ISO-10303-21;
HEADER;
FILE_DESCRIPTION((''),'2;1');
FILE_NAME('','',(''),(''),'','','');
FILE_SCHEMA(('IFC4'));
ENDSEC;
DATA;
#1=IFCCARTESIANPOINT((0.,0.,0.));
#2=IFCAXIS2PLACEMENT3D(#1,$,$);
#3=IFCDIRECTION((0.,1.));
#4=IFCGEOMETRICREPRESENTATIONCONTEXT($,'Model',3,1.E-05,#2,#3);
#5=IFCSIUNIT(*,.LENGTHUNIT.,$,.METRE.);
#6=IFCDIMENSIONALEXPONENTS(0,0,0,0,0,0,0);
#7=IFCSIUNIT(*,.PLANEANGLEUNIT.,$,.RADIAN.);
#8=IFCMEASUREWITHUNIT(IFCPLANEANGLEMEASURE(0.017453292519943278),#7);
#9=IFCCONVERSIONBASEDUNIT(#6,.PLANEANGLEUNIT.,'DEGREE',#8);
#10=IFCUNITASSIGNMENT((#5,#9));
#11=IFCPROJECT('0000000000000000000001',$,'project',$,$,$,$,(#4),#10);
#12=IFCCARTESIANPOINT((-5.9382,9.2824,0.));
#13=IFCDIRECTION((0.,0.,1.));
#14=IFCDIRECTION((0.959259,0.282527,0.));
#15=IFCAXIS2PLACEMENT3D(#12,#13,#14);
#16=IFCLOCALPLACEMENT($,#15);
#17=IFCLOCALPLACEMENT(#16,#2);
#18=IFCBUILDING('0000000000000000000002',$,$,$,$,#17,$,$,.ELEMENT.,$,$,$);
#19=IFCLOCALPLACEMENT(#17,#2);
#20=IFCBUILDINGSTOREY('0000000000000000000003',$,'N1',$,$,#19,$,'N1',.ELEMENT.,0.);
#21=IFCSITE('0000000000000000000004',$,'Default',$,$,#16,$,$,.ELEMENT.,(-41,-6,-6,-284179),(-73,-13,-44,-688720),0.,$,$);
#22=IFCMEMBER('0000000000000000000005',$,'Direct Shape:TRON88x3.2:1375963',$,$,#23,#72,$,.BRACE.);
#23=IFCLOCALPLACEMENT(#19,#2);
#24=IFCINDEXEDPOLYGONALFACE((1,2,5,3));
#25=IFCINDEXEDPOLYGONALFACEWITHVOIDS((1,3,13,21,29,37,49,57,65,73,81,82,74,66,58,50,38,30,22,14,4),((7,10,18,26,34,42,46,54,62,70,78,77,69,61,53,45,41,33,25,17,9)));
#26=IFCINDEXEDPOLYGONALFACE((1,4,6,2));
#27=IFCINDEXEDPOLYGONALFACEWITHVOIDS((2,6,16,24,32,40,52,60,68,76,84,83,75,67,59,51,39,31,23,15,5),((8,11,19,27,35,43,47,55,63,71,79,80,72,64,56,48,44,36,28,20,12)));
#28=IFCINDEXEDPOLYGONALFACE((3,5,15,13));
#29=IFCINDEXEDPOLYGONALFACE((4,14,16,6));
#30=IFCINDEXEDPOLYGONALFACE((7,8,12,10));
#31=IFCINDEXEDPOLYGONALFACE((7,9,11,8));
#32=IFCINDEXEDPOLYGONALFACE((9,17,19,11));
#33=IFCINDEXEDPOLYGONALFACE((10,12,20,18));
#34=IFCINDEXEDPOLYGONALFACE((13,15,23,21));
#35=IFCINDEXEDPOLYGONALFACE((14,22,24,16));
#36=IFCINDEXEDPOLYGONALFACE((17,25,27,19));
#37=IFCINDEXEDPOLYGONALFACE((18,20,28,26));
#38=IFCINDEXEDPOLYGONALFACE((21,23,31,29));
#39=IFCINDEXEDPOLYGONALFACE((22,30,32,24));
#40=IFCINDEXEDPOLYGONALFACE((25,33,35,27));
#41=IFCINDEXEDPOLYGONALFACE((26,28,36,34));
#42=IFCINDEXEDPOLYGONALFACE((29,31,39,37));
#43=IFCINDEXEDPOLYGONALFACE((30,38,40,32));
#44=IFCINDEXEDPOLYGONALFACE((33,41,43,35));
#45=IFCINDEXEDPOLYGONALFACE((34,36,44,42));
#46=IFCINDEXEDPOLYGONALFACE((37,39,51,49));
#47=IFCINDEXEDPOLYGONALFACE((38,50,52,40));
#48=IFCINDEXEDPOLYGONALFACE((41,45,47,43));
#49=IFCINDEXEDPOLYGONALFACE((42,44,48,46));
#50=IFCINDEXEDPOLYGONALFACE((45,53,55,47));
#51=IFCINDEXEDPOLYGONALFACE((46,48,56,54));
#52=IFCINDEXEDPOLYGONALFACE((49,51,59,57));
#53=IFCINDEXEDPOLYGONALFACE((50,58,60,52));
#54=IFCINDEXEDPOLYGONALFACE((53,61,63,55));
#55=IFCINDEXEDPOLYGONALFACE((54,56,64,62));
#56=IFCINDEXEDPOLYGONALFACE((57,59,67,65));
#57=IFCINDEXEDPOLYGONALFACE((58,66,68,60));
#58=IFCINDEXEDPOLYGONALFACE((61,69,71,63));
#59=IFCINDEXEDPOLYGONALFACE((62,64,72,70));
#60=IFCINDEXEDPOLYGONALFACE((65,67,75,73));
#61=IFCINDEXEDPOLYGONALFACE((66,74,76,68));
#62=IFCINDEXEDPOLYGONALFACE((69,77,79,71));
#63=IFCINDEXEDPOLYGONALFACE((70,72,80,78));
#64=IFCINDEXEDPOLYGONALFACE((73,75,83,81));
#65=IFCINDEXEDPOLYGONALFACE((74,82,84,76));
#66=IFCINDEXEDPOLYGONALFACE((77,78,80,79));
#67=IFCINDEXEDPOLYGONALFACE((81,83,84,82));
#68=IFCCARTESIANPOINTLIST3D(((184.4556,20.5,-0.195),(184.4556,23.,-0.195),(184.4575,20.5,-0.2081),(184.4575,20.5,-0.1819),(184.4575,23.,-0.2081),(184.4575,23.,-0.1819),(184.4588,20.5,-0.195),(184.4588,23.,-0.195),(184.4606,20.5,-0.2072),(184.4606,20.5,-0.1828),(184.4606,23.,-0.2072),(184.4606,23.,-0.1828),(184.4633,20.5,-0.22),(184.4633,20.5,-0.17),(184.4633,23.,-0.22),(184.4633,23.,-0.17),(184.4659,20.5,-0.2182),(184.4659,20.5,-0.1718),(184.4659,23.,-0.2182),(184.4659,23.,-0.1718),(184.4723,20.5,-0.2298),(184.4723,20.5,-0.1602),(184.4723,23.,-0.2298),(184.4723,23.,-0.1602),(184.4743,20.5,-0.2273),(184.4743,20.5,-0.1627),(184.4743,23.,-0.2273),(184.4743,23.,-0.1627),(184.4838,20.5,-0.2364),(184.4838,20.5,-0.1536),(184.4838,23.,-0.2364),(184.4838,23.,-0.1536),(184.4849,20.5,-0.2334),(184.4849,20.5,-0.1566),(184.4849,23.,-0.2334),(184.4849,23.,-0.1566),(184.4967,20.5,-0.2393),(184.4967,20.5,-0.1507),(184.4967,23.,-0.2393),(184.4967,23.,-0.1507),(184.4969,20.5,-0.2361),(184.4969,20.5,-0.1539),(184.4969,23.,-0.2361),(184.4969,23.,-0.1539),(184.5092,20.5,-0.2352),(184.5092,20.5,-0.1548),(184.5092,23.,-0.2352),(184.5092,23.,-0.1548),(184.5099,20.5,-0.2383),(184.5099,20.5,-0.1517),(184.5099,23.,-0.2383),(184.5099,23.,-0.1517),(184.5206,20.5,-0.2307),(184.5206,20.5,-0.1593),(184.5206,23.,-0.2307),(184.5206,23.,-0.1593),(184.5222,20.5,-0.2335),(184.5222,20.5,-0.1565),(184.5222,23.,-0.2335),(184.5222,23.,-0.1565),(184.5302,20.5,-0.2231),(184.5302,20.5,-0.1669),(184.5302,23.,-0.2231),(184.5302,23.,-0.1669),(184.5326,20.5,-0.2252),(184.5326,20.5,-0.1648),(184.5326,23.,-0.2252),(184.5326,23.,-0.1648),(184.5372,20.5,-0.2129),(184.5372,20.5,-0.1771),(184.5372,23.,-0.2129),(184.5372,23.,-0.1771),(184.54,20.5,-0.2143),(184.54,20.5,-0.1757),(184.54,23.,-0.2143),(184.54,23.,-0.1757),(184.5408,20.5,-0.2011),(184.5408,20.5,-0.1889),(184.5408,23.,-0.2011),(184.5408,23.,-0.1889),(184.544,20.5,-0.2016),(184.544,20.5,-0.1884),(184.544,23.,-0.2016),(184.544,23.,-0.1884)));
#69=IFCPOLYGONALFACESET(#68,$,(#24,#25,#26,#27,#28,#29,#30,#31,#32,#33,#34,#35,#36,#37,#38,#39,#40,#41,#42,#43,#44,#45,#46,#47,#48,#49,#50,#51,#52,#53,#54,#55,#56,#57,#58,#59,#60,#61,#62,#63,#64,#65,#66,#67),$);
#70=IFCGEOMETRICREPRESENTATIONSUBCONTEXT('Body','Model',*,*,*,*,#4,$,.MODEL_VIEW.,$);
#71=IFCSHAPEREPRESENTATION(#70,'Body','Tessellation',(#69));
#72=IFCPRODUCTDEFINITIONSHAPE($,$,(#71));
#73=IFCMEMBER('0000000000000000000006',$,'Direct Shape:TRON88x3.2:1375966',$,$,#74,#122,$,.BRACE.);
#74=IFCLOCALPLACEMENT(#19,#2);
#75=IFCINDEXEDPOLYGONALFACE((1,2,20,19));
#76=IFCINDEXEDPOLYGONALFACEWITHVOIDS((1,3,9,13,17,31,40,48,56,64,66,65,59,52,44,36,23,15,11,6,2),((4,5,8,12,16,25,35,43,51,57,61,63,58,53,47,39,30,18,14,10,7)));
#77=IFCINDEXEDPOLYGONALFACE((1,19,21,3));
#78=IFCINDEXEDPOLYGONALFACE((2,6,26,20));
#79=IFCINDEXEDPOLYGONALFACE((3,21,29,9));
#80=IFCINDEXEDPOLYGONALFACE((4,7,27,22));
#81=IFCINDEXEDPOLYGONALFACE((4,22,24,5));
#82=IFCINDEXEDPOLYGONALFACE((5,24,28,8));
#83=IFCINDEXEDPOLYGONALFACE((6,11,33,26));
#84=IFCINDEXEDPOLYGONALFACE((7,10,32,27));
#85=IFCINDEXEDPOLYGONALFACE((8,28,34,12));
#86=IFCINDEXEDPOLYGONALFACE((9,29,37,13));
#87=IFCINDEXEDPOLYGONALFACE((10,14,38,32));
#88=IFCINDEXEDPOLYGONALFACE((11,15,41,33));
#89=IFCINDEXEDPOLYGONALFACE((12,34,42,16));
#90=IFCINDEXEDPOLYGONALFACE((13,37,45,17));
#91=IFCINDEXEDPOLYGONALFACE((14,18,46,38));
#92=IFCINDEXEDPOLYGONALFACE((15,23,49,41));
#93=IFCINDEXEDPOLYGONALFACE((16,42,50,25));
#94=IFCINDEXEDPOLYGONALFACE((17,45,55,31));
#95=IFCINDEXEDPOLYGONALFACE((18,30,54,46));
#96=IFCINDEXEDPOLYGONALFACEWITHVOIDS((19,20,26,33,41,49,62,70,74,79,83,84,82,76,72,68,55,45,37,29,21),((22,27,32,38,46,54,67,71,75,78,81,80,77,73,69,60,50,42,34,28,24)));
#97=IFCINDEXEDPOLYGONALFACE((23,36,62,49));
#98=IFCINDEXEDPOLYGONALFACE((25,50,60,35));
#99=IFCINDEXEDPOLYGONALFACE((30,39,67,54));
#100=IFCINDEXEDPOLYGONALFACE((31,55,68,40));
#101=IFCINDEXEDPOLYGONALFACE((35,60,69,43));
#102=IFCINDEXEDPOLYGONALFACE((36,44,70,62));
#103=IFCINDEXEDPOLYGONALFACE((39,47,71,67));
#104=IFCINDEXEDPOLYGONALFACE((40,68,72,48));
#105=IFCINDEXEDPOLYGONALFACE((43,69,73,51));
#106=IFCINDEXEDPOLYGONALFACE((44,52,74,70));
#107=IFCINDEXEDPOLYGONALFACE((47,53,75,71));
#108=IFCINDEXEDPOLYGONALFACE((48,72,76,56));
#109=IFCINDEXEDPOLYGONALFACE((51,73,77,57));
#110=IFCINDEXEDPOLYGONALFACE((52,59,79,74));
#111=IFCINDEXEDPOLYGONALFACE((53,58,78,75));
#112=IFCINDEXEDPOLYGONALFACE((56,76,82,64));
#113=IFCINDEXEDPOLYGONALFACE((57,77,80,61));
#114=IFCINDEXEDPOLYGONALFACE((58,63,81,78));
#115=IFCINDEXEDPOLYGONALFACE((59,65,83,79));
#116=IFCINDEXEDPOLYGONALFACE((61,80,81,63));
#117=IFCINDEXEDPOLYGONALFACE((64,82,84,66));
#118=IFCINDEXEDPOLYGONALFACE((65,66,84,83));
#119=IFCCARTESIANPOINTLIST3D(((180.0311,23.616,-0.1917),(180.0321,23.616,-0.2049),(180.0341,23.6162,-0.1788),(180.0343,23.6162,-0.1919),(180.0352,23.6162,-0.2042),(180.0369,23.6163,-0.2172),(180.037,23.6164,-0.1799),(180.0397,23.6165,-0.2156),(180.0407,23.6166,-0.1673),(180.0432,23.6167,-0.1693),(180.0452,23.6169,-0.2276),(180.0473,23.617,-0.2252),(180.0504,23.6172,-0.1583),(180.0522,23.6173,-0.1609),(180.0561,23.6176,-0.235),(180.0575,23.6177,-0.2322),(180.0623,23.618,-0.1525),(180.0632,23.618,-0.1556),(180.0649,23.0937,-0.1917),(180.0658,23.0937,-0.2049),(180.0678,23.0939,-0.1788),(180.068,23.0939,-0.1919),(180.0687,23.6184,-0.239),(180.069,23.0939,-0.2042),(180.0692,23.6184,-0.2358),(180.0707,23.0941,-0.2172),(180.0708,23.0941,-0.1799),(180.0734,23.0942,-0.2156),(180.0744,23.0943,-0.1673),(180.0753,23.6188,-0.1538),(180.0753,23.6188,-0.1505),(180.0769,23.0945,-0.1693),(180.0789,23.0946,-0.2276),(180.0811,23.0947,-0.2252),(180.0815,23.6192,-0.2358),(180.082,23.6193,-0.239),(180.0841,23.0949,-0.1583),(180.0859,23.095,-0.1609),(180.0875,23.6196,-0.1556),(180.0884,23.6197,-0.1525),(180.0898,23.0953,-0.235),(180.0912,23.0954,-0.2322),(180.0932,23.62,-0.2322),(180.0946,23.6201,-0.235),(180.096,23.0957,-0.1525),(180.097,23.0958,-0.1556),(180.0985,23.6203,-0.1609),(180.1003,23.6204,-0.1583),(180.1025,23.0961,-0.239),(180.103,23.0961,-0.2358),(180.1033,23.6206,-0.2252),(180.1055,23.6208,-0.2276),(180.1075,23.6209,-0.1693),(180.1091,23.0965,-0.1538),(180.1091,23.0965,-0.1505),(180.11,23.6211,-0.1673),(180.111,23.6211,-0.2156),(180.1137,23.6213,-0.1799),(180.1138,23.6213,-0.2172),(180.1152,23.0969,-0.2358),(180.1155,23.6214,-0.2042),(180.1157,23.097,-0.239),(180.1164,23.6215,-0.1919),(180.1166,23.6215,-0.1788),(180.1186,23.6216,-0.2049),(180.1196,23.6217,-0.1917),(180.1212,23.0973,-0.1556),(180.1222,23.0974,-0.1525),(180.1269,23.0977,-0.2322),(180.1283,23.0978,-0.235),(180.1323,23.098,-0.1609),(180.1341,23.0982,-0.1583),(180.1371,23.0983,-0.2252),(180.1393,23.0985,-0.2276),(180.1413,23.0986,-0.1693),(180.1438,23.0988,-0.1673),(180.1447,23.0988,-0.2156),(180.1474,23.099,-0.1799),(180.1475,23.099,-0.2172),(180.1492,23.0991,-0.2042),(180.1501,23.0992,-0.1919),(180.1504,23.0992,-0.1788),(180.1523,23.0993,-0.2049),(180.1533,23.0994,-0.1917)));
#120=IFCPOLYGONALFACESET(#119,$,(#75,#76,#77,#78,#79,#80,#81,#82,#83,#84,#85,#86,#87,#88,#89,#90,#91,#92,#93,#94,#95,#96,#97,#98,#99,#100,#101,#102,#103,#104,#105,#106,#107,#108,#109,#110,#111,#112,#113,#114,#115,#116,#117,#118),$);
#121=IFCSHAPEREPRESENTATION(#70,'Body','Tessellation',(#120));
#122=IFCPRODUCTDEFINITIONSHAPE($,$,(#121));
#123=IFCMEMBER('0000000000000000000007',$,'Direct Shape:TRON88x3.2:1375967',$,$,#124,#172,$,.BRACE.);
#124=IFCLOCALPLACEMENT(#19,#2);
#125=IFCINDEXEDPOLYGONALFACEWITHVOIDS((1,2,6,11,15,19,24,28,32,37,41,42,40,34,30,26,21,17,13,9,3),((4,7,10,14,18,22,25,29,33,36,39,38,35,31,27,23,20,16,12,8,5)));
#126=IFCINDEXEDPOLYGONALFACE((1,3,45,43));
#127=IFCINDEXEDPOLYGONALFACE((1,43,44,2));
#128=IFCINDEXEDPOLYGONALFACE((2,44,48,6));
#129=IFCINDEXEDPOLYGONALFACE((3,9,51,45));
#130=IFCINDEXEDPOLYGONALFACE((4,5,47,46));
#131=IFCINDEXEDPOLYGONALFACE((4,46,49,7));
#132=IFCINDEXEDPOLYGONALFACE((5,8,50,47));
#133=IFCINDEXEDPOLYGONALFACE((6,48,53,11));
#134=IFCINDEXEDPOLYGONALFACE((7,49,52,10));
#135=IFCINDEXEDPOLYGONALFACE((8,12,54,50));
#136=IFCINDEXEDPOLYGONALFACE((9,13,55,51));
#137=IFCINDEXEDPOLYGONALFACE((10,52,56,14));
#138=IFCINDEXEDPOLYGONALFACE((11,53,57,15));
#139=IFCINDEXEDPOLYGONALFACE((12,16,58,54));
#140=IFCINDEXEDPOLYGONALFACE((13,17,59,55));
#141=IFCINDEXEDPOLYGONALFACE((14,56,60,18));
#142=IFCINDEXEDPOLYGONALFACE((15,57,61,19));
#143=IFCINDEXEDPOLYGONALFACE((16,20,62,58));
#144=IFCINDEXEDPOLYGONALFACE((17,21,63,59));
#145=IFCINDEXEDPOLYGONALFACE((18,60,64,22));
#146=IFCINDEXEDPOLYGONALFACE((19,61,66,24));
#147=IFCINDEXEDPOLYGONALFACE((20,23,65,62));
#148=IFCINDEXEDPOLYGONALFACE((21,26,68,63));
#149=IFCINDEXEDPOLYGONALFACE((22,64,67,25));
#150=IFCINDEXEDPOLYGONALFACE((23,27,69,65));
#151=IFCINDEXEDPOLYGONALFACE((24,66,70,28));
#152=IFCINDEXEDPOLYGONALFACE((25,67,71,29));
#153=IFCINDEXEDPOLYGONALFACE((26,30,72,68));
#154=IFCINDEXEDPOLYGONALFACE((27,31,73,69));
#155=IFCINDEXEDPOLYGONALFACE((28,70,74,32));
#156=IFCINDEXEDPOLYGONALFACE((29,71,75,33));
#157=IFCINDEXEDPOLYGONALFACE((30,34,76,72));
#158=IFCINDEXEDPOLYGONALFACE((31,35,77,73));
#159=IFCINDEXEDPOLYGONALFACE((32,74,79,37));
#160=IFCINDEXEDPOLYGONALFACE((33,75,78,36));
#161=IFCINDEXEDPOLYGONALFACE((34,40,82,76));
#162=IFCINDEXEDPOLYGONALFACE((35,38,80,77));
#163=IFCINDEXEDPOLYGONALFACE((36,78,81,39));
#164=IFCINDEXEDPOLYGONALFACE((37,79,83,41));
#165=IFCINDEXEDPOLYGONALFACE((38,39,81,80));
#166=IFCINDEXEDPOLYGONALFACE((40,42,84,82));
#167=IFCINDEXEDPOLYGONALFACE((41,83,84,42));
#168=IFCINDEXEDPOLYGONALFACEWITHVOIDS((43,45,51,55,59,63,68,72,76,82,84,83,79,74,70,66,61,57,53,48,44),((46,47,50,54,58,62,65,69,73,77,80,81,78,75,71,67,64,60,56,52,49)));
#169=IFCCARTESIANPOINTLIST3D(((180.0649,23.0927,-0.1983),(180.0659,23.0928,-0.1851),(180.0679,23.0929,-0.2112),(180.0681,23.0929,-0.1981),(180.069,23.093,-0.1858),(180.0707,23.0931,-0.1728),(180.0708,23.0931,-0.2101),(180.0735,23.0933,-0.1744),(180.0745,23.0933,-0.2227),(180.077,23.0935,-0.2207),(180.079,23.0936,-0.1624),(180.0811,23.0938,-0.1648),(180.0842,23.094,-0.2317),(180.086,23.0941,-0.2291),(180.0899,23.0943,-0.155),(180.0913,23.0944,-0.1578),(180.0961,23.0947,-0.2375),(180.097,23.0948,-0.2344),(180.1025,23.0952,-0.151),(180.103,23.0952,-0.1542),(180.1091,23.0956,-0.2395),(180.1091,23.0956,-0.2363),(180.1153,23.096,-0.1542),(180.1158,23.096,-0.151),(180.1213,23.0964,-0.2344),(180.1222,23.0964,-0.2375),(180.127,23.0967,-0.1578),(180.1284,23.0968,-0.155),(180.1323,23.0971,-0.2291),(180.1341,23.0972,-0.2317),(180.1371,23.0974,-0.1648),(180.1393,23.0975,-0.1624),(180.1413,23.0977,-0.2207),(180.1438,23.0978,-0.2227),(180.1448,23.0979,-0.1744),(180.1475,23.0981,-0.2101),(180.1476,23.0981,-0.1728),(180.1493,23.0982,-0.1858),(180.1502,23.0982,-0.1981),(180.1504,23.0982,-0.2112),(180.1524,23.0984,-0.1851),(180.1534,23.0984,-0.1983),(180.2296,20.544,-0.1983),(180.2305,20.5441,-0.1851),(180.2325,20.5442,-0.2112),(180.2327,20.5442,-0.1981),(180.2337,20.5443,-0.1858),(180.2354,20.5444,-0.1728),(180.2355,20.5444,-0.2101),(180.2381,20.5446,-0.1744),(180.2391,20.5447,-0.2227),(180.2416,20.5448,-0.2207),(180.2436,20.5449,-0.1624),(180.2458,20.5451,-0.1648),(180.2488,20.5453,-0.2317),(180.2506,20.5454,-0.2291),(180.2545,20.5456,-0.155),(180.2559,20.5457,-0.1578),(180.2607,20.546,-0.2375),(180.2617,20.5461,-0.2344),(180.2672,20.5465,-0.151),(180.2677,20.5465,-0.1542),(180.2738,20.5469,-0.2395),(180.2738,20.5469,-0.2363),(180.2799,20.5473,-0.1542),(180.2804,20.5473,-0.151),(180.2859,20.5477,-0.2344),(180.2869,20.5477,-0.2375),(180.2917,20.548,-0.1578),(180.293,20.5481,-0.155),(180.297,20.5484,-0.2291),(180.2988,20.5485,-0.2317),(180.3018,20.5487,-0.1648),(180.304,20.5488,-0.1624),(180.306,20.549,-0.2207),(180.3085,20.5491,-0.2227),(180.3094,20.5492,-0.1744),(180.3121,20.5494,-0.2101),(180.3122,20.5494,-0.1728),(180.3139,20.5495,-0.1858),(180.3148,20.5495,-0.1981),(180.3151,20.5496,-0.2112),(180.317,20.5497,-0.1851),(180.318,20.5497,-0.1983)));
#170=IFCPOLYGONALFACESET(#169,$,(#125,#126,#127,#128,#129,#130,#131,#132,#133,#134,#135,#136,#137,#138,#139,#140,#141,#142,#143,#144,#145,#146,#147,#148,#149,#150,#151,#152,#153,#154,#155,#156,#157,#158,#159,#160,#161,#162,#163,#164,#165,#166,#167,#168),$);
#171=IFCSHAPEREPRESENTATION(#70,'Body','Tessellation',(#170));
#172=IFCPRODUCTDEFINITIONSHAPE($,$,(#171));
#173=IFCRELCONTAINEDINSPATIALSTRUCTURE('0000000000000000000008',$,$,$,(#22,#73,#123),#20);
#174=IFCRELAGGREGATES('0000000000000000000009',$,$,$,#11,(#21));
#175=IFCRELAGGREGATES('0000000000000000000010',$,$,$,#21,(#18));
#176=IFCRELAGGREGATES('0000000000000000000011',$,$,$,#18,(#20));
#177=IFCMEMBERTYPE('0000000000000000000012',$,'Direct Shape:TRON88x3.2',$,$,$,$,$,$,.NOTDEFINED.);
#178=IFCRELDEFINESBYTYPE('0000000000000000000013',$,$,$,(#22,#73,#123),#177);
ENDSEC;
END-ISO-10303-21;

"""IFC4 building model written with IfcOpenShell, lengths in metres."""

from ifc_helpers import new_model, entity, si_unit, converted_unit, direction, frame, frame_2d, origin, place, context, subcontext, project, spatial, hollow_circle, extrude, type_object, element, save


model = new_model("IFC4")

# Units and contexts
model_context = context("Model", 3, precision=1e-05, world=origin(), true_north=direction((0.0, 1.0)))
body_context = subcontext(model_context, "Body", "Model", "MODEL_VIEW")
ifc_project = project(units=[si_unit("LENGTHUNIT", "METRE"), converted_unit("PLANEANGLEUNIT", "DEGREE", entity("IfcPlaneAngleMeasure", 0.017453292519943278), si_unit("PLANEANGLEUNIT", "RADIAN"), dimensions=[0, 0, 0, 0, 0, 0, 0])], contexts=[model_context])

# Site, building, storey
site_placement = place(None, frame((-5.9382, 9.2824, 0.0), z_axis=(0.0, 0.0, 1.0), x_axis=(0.959259, 0.282527, 0.0)))
site = spatial("IfcSite", under=ifc_project, at=site_placement, Name="Default", CompositionType="ELEMENT", RefLatitude=(-41, -6, -6, -284179), RefLongitude=(-73, -13, -44, -688720), RefElevation=0.0)
building_placement = place(site_placement, origin())
building = spatial("IfcBuilding", under=site, at=building_placement, CompositionType="ELEMENT")
storey_placement = place(building_placement, origin())
storey = spatial("IfcBuildingStorey", under=building, at=storey_placement, Name="N1", LongName="N1", CompositionType="ELEMENT", Elevation=0.0)

# Members
member_type_1 = type_object("IfcMemberType", Name="Direct Shape:TRON88x3.2", PredefinedType="NOTDEFINED")
member_1_placement = place(storey_placement, origin())
element("IfcMember", 1, at=member_1_placement, inside=storey, type_object=member_type_1, Name="Direct Shape:TRON88x3.2:1375963", PredefinedType="BRACE", context=body_context, shape_type="SweptSolid", body=[
    extrude(hollow_circle(Radius=0.0445, WallThickness=0.0032, at=frame_2d((0.0, 0.0), x_axis=(1.0, 0.0))), frame((184.5, 20.5, -0.195), z_axis=(0.0, 1.0, 0.0), x_axis=(-1.0, 0.0, 0.0)), (0.0, 0.0, 1.0), 2.5),
])
member_2_placement = place(storey_placement, origin())
element("IfcMember", 2, at=member_2_placement, inside=storey, type_object=member_type_1, Name="Direct Shape:TRON88x3.2:1375966", PredefinedType="BRACE", context=body_context, shape_type="SweptSolid", body=[
    extrude(hollow_circle(Radius=0.0445, WallThickness=0.0032, at=frame_2d((0.0, 0.0), x_axis=(1.0, 0.0))), frame((180.1091, 23.0965, -0.195), z_axis=(-0.064465, 0.99792, 0.0), x_axis=(0.0, 0.0, 1.0)), (0.0, -0.000006, 1.0), 0.5234),
])
member_3_placement = place(storey_placement, origin())
element("IfcMember", 3, at=member_3_placement, inside=storey, type_object=member_type_1, Name="Direct Shape:TRON88x3.2:1375967", PredefinedType="BRACE", context=body_context, shape_type="SweptSolid", body=[
    extrude(hollow_circle(Radius=0.0445, WallThickness=0.0032, at=frame_2d((0.0, 0.0), x_axis=(1.0, 0.0))), frame((180.1091, 23.0956, -0.195), z_axis=(0.064465, -0.99792, 0.0), x_axis=(0.0, 0.0, -1.0)), (0.0, 0.0, 1.0), 2.554),
])

save(model, "model.ifc")
